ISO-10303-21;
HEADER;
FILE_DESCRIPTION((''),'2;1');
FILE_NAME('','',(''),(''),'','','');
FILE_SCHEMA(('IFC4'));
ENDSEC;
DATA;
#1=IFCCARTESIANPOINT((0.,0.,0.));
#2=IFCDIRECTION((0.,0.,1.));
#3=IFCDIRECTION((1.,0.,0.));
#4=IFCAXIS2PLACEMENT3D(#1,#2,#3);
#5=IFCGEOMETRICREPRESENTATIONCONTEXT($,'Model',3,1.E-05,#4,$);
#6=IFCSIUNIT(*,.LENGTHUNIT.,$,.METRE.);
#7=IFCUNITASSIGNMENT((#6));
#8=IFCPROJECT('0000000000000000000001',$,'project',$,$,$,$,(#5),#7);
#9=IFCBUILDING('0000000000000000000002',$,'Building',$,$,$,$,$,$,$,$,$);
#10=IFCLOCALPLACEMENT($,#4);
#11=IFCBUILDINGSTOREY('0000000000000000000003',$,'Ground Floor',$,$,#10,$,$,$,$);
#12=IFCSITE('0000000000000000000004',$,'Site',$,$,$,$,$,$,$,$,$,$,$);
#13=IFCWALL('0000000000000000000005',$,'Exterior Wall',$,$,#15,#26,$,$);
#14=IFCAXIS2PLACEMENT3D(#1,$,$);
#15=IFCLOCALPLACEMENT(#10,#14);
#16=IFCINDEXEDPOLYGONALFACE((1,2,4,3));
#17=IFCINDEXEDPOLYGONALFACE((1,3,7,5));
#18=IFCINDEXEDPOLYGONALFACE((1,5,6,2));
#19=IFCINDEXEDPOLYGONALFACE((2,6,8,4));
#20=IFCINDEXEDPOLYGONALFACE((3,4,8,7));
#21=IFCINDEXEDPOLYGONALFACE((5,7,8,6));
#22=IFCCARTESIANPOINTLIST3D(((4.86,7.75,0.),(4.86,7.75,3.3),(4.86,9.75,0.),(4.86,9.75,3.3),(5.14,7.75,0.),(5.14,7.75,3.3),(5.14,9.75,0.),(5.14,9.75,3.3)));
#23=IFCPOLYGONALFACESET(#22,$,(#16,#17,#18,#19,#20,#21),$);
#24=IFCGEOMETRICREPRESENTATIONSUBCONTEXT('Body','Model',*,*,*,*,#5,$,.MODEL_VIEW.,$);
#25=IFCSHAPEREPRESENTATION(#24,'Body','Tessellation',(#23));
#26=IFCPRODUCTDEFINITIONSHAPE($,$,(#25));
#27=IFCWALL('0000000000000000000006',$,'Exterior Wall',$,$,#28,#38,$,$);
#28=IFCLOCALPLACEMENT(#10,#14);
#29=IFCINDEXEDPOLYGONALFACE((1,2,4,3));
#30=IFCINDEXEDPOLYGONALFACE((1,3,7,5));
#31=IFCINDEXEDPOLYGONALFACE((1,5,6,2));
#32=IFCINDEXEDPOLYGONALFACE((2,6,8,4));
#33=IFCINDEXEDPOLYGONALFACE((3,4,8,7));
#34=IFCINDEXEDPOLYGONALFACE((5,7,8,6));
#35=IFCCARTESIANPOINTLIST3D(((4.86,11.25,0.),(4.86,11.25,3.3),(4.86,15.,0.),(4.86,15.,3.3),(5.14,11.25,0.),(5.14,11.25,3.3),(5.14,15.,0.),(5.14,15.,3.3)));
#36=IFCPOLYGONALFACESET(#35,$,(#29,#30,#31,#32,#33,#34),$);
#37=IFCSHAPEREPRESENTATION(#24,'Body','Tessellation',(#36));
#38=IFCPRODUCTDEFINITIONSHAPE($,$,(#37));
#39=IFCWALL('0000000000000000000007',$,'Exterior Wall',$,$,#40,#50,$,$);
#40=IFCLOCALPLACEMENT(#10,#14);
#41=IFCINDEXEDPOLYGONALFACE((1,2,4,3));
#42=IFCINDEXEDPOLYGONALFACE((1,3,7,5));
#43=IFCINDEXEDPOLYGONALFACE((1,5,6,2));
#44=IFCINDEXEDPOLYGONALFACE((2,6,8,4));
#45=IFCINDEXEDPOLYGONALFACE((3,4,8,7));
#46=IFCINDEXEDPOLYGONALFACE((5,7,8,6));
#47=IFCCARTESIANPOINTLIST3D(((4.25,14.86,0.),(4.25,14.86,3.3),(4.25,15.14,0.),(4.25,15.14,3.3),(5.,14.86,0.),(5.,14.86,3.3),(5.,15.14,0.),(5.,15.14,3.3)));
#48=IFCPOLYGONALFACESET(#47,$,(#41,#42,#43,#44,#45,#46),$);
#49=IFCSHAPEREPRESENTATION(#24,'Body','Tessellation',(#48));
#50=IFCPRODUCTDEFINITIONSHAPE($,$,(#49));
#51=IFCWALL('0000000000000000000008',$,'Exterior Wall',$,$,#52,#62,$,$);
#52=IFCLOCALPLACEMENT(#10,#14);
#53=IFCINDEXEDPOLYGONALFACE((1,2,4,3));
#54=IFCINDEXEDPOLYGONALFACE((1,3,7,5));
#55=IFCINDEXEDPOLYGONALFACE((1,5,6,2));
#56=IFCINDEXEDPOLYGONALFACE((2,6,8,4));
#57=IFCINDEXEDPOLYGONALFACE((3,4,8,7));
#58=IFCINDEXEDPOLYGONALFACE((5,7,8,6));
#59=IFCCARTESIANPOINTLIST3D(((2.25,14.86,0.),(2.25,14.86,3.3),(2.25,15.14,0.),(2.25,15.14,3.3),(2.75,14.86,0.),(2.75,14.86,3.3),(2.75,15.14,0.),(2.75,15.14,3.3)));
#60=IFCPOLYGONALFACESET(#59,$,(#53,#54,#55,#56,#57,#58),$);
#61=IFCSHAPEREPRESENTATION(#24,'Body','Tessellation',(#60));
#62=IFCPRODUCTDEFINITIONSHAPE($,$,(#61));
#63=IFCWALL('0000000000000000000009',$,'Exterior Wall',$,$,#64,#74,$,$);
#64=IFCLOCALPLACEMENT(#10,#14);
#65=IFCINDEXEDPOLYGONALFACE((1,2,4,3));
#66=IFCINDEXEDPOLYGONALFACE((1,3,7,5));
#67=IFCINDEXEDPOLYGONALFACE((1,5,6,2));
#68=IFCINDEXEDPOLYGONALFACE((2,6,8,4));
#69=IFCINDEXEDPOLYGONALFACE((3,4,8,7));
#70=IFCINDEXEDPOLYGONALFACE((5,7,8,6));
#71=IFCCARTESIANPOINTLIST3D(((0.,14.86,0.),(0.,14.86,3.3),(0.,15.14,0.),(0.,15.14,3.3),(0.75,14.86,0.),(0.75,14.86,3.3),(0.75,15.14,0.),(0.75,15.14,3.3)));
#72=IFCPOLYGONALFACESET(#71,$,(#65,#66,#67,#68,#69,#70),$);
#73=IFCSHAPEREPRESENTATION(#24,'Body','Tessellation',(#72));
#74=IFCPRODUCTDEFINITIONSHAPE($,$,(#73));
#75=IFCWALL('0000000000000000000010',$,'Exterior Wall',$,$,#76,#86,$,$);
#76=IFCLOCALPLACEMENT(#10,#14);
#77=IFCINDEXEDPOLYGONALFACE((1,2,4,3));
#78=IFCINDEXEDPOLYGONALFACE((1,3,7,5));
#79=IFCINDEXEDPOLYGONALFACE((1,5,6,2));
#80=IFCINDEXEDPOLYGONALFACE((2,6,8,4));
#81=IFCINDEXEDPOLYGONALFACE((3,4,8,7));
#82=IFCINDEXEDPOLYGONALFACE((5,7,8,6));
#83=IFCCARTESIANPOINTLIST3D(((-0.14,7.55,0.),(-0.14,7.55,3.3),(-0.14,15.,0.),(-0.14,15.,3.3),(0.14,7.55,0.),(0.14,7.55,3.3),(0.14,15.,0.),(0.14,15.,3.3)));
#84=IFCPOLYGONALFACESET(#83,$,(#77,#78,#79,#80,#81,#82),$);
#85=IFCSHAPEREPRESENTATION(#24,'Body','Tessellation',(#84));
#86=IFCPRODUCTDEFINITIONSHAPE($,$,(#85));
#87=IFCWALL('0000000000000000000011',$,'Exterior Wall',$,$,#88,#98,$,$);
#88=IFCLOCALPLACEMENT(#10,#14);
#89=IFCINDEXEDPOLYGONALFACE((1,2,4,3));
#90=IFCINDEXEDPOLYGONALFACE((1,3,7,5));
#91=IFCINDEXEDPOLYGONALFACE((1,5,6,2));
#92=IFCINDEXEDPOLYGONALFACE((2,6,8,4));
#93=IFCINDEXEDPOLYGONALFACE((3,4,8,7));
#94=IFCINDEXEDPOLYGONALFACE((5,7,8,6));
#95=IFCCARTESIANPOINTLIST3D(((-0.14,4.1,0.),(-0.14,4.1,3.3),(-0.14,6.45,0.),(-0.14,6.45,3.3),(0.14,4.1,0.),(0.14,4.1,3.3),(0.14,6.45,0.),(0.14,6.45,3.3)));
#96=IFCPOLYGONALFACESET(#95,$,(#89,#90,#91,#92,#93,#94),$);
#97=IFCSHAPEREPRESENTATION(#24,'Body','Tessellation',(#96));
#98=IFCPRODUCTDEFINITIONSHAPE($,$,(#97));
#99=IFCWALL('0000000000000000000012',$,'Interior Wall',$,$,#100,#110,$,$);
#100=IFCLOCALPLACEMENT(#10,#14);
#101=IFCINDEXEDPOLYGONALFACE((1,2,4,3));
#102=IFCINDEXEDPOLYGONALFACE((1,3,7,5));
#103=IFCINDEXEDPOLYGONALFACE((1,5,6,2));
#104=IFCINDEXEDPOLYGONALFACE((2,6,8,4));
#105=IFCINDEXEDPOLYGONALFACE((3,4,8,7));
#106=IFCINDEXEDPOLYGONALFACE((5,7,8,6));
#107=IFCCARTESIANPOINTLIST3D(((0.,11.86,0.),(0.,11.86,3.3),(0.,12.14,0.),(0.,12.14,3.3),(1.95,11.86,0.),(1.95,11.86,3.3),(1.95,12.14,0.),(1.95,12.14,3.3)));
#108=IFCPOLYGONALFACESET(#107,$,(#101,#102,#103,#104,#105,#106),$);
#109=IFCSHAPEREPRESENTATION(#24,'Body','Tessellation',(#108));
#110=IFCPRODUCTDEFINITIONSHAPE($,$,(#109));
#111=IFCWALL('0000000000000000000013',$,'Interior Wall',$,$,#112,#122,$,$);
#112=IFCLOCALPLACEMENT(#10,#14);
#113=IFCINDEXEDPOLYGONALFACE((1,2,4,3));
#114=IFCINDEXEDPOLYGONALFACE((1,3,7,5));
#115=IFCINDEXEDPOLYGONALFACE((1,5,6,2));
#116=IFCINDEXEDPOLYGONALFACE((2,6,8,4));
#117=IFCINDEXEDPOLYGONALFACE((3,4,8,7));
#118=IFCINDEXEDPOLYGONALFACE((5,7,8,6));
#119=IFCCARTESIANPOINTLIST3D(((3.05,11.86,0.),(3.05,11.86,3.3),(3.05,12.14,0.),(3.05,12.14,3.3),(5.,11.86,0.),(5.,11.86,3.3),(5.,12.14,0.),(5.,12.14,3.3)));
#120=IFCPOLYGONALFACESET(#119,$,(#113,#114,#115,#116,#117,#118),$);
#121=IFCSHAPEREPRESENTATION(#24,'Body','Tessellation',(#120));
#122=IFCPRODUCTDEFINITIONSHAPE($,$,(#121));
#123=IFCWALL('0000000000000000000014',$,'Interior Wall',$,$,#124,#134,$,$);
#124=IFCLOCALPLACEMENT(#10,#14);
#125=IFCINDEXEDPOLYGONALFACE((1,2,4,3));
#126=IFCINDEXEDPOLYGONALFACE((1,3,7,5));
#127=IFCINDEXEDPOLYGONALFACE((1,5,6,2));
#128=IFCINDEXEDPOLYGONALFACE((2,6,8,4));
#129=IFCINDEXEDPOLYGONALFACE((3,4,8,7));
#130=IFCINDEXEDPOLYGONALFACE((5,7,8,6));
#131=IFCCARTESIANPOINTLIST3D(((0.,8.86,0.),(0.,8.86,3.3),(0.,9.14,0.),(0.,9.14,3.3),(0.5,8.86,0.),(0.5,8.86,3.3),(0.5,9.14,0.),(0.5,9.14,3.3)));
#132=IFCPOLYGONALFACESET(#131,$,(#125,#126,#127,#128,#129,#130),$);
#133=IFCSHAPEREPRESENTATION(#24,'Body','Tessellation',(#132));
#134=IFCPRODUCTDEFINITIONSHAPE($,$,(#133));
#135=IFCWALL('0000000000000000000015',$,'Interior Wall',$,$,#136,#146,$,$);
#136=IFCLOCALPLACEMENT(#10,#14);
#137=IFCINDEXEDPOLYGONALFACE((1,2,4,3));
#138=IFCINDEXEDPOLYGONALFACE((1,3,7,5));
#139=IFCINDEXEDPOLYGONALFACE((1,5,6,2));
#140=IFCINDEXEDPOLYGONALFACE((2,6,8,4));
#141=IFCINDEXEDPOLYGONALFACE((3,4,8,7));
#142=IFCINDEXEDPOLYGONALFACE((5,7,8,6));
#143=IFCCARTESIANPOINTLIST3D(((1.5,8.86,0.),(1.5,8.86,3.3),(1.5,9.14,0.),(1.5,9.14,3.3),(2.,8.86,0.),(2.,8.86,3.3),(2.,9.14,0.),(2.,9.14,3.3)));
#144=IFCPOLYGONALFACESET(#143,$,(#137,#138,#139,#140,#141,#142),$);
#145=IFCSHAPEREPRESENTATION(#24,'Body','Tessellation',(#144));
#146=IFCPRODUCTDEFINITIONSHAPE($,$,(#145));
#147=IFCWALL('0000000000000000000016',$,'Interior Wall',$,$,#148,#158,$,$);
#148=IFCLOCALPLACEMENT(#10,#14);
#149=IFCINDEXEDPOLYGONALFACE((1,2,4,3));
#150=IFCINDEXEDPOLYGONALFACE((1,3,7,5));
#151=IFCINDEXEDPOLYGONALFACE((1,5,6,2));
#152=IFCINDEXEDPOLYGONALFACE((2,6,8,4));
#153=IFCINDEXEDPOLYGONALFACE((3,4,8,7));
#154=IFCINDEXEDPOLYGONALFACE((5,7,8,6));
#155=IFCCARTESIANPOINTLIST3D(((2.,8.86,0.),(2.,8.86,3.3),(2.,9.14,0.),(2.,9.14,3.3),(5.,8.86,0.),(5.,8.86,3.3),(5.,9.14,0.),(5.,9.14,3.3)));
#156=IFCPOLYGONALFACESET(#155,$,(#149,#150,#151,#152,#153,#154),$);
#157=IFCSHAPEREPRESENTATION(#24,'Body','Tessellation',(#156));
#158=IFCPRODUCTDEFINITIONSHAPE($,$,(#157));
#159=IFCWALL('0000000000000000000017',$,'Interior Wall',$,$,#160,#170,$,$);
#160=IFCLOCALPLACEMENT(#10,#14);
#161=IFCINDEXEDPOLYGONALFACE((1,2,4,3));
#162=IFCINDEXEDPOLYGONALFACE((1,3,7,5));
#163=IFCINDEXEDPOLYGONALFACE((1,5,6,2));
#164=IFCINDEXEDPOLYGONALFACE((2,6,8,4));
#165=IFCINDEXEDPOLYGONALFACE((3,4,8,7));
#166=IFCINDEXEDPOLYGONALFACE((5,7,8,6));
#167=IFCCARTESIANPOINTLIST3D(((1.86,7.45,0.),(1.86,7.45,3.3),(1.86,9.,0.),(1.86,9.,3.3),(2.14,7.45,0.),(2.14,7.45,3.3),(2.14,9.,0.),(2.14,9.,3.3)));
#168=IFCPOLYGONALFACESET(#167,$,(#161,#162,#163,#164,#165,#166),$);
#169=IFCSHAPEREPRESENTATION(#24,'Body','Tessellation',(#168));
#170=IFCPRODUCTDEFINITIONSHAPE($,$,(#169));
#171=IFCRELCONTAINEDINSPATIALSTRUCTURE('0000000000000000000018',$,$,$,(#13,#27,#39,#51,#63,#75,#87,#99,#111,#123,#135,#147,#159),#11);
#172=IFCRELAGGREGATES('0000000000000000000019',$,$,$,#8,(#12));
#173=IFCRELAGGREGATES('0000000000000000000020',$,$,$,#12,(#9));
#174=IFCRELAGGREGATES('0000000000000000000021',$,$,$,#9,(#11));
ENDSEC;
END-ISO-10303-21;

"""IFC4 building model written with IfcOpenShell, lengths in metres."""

from ifc_helpers import new_model, si_unit, frame, origin_with_axes, place, context, subcontext, project, spatial, indexed_curve, outline, extrude, element, save


model = new_model("IFC4")

# Units and contexts
model_context = context("Model", 3, precision=1e-05, world=origin_with_axes())
body_context = subcontext(model_context, "Body", "Model", "MODEL_VIEW")
ifc_project = project(units=[si_unit("LENGTHUNIT", "METRE")], contexts=[model_context])

# Site, building, storey
site = spatial("IfcSite", under=ifc_project, Name="Site")
building = spatial("IfcBuilding", under=site, Name="Building")
storey_placement = place(None, origin_with_axes())
storey = spatial("IfcBuildingStorey", under=building, at=storey_placement, Name="Ground Floor")

# Walls
wall_1_placement = place(storey_placement, frame((5.0, 7.75, 0.0), z_axis=(0.0, 0.0, 1.0), x_axis=(0.0, 1.0, 0.0)))
element("IfcWall", 1, at=wall_1_placement, inside=storey, Name="Exterior Wall", context=body_context, shape_type="SweptSolid", body=[
    extrude(outline(indexed_curve([(0.0, 0.0), (0.0, 0.28), (2.0, 0.28), (2.0, 0.0), (0.0, 0.0)], self_intersect=False)), frame((0.0, -0.14, 0.0), z_axis=(0.0, 0.0, 1.0), x_axis=(1.0, 0.0, 0.0)), (0.0, 0.0, 1.0), 3.3),
])
wall_2_placement = place(storey_placement, frame((5.0, 11.25, 0.0), z_axis=(0.0, 0.0, 1.0), x_axis=(0.0, 1.0, 0.0)))
element("IfcWall", 2, at=wall_2_placement, inside=storey, Name="Exterior Wall", context=body_context, shape_type="SweptSolid", body=[
    extrude(outline(indexed_curve([(0.0, 0.0), (0.0, 0.28), (3.75, 0.28), (3.75, 0.0), (0.0, 0.0)], self_intersect=False)), frame((0.0, -0.14, 0.0), z_axis=(0.0, 0.0, 1.0), x_axis=(1.0, 0.0, 0.0)), (0.0, 0.0, 1.0), 3.3),
])
wall_3_placement = place(storey_placement, frame((5.0, 15.0, 0.0), z_axis=(0.0, 0.0, 1.0), x_axis=(-1.0, 0.0, 0.0)))
element("IfcWall", 3, at=wall_3_placement, inside=storey, Name="Exterior Wall", context=body_context, shape_type="SweptSolid", body=[
    extrude(outline(indexed_curve([(0.0, 0.0), (0.0, 0.28), (0.75, 0.28), (0.75, 0.0), (0.0, 0.0)], self_intersect=False)), frame((0.0, -0.14, 0.0), z_axis=(0.0, 0.0, 1.0), x_axis=(1.0, 0.0, 0.0)), (0.0, 0.0, 1.0), 3.3),
])
wall_4_placement = place(storey_placement, frame((2.75, 15.0, 0.0), z_axis=(0.0, 0.0, 1.0), x_axis=(-1.0, 0.0, 0.0)))
element("IfcWall", 4, at=wall_4_placement, inside=storey, Name="Exterior Wall", context=body_context, shape_type="SweptSolid", body=[
    extrude(outline(indexed_curve([(0.0, 0.0), (0.0, 0.28), (0.5, 0.28), (0.5, 0.0), (0.0, 0.0)], self_intersect=False)), frame((0.0, -0.14, 0.0), z_axis=(0.0, 0.0, 1.0), x_axis=(1.0, 0.0, 0.0)), (0.0, 0.0, 1.0), 3.3),
])
wall_5_placement = place(storey_placement, frame((0.75, 15.0, 0.0), z_axis=(0.0, 0.0, 1.0), x_axis=(-1.0, 0.0, 0.0)))
element("IfcWall", 5, at=wall_5_placement, inside=storey, Name="Exterior Wall", context=body_context, shape_type="SweptSolid", body=[
    extrude(outline(indexed_curve([(0.0, 0.0), (0.0, 0.28), (0.75, 0.28), (0.75, 0.0), (0.0, 0.0)], self_intersect=False)), frame((0.0, -0.14, 0.0), z_axis=(0.0, 0.0, 1.0), x_axis=(1.0, 0.0, 0.0)), (0.0, 0.0, 1.0), 3.3),
])
wall_6_placement = place(storey_placement, frame((0.0, 15.0, 0.0), z_axis=(0.0, 0.0, 1.0), x_axis=(0.0, -1.0, 0.0)))
element("IfcWall", 6, at=wall_6_placement, inside=storey, Name="Exterior Wall", context=body_context, shape_type="SweptSolid", body=[
    extrude(outline(indexed_curve([(0.0, 0.0), (0.0, 0.28), (7.45, 0.28), (7.45, 0.0), (0.0, 0.0)], self_intersect=False)), frame((0.0, -0.14, 0.0), z_axis=(0.0, 0.0, 1.0), x_axis=(1.0, 0.0, 0.0)), (0.0, 0.0, 1.0), 3.3),
])
wall_7_placement = place(storey_placement, frame((0.0, 6.45, 0.0), z_axis=(0.0, 0.0, 1.0), x_axis=(0.0, -1.0, 0.0)))
element("IfcWall", 7, at=wall_7_placement, inside=storey, Name="Exterior Wall", context=body_context, shape_type="SweptSolid", body=[
    extrude(outline(indexed_curve([(0.0, 0.0), (0.0, 0.28), (2.35, 0.28), (2.35, 0.0), (0.0, 0.0)], self_intersect=False)), frame((0.0, -0.14, 0.0), z_axis=(0.0, 0.0, 1.0), x_axis=(1.0, 0.0, 0.0)), (0.0, 0.0, 1.0), 3.3),
])
wall_8_placement = place(storey_placement, frame((0.0, 12.0, 0.0), z_axis=(0.0, 0.0, 1.0), x_axis=(1.0, 0.0, 0.0)))
element("IfcWall", 8, at=wall_8_placement, inside=storey, Name="Interior Wall", context=body_context, shape_type="SweptSolid", body=[
    extrude(outline(indexed_curve([(0.0, 0.0), (0.0, 0.28), (1.95, 0.28), (1.95, 0.0), (0.0, 0.0)], self_intersect=False)), frame((0.0, -0.14, 0.0), z_axis=(0.0, 0.0, 1.0), x_axis=(1.0, 0.0, 0.0)), (0.0, 0.0, 1.0), 3.3),
])
wall_9_placement = place(storey_placement, frame((3.05, 12.0, 0.0), z_axis=(0.0, 0.0, 1.0), x_axis=(1.0, 0.0, 0.0)))
element("IfcWall", 9, at=wall_9_placement, inside=storey, Name="Interior Wall", context=body_context, shape_type="SweptSolid", body=[
    extrude(outline(indexed_curve([(0.0, 0.0), (0.0, 0.28), (1.95, 0.28), (1.95, 0.0), (0.0, 0.0)], self_intersect=False)), frame((0.0, -0.14, 0.0), z_axis=(0.0, 0.0, 1.0), x_axis=(1.0, 0.0, 0.0)), (0.0, 0.0, 1.0), 3.3),
])
for number, where, z_axis, x_axis, name in (
    (10, (0.0, 9.0, 0.0), (0.0, 0.0, 1.0), (1.0, 0.0, 0.0), "Interior Wall"),
    (11, (1.5, 9.0, 0.0), (0.0, 0.0, 1.0), (1.0, 0.0, 0.0), "Interior Wall"),
):
    element("IfcWall", number, at=place(storey_placement, frame(where, z_axis=z_axis, x_axis=x_axis)), inside=storey, Name=name, context=body_context, shape_type="SweptSolid", body=[
        extrude(outline(indexed_curve([(0.0, 0.0), (0.0, 0.28), (0.5, 0.28), (0.5, 0.0), (0.0, 0.0)], self_intersect=False)), frame((0.0, -0.14, 0.0), z_axis=(0.0, 0.0, 1.0), x_axis=(1.0, 0.0, 0.0)), (0.0, 0.0, 1.0), 3.3),
    ])
wall_10_placement = place(storey_placement, frame((2.0, 9.0, 0.0), z_axis=(0.0, 0.0, 1.0), x_axis=(1.0, 0.0, 0.0)))
element("IfcWall", 12, at=wall_10_placement, inside=storey, Name="Interior Wall", context=body_context, shape_type="SweptSolid", body=[
    extrude(outline(indexed_curve([(0.0, 0.0), (0.0, 0.28), (3.0, 0.28), (3.0, 0.0), (0.0, 0.0)], self_intersect=False)), frame((0.0, -0.14, 0.0), z_axis=(0.0, 0.0, 1.0), x_axis=(1.0, 0.0, 0.0)), (0.0, 0.0, 1.0), 3.3),
])
wall_11_placement = place(storey_placement, frame((2.0, 7.45, 0.0), z_axis=(0.0, 0.0, 1.0), x_axis=(0.0, 1.0, 0.0)))
element("IfcWall", 13, at=wall_11_placement, inside=storey, Name="Interior Wall", context=body_context, shape_type="SweptSolid", body=[
    extrude(outline(indexed_curve([(0.0, 0.0), (0.0, 0.28), (1.55, 0.28), (1.55, 0.0), (0.0, 0.0)], self_intersect=False)), frame((0.0, -0.14, 0.0), z_axis=(0.0, 0.0, 1.0), x_axis=(1.0, 0.0, 0.0)), (0.0, 0.0, 1.0), 3.3),
])

save(model, "model.ifc")
